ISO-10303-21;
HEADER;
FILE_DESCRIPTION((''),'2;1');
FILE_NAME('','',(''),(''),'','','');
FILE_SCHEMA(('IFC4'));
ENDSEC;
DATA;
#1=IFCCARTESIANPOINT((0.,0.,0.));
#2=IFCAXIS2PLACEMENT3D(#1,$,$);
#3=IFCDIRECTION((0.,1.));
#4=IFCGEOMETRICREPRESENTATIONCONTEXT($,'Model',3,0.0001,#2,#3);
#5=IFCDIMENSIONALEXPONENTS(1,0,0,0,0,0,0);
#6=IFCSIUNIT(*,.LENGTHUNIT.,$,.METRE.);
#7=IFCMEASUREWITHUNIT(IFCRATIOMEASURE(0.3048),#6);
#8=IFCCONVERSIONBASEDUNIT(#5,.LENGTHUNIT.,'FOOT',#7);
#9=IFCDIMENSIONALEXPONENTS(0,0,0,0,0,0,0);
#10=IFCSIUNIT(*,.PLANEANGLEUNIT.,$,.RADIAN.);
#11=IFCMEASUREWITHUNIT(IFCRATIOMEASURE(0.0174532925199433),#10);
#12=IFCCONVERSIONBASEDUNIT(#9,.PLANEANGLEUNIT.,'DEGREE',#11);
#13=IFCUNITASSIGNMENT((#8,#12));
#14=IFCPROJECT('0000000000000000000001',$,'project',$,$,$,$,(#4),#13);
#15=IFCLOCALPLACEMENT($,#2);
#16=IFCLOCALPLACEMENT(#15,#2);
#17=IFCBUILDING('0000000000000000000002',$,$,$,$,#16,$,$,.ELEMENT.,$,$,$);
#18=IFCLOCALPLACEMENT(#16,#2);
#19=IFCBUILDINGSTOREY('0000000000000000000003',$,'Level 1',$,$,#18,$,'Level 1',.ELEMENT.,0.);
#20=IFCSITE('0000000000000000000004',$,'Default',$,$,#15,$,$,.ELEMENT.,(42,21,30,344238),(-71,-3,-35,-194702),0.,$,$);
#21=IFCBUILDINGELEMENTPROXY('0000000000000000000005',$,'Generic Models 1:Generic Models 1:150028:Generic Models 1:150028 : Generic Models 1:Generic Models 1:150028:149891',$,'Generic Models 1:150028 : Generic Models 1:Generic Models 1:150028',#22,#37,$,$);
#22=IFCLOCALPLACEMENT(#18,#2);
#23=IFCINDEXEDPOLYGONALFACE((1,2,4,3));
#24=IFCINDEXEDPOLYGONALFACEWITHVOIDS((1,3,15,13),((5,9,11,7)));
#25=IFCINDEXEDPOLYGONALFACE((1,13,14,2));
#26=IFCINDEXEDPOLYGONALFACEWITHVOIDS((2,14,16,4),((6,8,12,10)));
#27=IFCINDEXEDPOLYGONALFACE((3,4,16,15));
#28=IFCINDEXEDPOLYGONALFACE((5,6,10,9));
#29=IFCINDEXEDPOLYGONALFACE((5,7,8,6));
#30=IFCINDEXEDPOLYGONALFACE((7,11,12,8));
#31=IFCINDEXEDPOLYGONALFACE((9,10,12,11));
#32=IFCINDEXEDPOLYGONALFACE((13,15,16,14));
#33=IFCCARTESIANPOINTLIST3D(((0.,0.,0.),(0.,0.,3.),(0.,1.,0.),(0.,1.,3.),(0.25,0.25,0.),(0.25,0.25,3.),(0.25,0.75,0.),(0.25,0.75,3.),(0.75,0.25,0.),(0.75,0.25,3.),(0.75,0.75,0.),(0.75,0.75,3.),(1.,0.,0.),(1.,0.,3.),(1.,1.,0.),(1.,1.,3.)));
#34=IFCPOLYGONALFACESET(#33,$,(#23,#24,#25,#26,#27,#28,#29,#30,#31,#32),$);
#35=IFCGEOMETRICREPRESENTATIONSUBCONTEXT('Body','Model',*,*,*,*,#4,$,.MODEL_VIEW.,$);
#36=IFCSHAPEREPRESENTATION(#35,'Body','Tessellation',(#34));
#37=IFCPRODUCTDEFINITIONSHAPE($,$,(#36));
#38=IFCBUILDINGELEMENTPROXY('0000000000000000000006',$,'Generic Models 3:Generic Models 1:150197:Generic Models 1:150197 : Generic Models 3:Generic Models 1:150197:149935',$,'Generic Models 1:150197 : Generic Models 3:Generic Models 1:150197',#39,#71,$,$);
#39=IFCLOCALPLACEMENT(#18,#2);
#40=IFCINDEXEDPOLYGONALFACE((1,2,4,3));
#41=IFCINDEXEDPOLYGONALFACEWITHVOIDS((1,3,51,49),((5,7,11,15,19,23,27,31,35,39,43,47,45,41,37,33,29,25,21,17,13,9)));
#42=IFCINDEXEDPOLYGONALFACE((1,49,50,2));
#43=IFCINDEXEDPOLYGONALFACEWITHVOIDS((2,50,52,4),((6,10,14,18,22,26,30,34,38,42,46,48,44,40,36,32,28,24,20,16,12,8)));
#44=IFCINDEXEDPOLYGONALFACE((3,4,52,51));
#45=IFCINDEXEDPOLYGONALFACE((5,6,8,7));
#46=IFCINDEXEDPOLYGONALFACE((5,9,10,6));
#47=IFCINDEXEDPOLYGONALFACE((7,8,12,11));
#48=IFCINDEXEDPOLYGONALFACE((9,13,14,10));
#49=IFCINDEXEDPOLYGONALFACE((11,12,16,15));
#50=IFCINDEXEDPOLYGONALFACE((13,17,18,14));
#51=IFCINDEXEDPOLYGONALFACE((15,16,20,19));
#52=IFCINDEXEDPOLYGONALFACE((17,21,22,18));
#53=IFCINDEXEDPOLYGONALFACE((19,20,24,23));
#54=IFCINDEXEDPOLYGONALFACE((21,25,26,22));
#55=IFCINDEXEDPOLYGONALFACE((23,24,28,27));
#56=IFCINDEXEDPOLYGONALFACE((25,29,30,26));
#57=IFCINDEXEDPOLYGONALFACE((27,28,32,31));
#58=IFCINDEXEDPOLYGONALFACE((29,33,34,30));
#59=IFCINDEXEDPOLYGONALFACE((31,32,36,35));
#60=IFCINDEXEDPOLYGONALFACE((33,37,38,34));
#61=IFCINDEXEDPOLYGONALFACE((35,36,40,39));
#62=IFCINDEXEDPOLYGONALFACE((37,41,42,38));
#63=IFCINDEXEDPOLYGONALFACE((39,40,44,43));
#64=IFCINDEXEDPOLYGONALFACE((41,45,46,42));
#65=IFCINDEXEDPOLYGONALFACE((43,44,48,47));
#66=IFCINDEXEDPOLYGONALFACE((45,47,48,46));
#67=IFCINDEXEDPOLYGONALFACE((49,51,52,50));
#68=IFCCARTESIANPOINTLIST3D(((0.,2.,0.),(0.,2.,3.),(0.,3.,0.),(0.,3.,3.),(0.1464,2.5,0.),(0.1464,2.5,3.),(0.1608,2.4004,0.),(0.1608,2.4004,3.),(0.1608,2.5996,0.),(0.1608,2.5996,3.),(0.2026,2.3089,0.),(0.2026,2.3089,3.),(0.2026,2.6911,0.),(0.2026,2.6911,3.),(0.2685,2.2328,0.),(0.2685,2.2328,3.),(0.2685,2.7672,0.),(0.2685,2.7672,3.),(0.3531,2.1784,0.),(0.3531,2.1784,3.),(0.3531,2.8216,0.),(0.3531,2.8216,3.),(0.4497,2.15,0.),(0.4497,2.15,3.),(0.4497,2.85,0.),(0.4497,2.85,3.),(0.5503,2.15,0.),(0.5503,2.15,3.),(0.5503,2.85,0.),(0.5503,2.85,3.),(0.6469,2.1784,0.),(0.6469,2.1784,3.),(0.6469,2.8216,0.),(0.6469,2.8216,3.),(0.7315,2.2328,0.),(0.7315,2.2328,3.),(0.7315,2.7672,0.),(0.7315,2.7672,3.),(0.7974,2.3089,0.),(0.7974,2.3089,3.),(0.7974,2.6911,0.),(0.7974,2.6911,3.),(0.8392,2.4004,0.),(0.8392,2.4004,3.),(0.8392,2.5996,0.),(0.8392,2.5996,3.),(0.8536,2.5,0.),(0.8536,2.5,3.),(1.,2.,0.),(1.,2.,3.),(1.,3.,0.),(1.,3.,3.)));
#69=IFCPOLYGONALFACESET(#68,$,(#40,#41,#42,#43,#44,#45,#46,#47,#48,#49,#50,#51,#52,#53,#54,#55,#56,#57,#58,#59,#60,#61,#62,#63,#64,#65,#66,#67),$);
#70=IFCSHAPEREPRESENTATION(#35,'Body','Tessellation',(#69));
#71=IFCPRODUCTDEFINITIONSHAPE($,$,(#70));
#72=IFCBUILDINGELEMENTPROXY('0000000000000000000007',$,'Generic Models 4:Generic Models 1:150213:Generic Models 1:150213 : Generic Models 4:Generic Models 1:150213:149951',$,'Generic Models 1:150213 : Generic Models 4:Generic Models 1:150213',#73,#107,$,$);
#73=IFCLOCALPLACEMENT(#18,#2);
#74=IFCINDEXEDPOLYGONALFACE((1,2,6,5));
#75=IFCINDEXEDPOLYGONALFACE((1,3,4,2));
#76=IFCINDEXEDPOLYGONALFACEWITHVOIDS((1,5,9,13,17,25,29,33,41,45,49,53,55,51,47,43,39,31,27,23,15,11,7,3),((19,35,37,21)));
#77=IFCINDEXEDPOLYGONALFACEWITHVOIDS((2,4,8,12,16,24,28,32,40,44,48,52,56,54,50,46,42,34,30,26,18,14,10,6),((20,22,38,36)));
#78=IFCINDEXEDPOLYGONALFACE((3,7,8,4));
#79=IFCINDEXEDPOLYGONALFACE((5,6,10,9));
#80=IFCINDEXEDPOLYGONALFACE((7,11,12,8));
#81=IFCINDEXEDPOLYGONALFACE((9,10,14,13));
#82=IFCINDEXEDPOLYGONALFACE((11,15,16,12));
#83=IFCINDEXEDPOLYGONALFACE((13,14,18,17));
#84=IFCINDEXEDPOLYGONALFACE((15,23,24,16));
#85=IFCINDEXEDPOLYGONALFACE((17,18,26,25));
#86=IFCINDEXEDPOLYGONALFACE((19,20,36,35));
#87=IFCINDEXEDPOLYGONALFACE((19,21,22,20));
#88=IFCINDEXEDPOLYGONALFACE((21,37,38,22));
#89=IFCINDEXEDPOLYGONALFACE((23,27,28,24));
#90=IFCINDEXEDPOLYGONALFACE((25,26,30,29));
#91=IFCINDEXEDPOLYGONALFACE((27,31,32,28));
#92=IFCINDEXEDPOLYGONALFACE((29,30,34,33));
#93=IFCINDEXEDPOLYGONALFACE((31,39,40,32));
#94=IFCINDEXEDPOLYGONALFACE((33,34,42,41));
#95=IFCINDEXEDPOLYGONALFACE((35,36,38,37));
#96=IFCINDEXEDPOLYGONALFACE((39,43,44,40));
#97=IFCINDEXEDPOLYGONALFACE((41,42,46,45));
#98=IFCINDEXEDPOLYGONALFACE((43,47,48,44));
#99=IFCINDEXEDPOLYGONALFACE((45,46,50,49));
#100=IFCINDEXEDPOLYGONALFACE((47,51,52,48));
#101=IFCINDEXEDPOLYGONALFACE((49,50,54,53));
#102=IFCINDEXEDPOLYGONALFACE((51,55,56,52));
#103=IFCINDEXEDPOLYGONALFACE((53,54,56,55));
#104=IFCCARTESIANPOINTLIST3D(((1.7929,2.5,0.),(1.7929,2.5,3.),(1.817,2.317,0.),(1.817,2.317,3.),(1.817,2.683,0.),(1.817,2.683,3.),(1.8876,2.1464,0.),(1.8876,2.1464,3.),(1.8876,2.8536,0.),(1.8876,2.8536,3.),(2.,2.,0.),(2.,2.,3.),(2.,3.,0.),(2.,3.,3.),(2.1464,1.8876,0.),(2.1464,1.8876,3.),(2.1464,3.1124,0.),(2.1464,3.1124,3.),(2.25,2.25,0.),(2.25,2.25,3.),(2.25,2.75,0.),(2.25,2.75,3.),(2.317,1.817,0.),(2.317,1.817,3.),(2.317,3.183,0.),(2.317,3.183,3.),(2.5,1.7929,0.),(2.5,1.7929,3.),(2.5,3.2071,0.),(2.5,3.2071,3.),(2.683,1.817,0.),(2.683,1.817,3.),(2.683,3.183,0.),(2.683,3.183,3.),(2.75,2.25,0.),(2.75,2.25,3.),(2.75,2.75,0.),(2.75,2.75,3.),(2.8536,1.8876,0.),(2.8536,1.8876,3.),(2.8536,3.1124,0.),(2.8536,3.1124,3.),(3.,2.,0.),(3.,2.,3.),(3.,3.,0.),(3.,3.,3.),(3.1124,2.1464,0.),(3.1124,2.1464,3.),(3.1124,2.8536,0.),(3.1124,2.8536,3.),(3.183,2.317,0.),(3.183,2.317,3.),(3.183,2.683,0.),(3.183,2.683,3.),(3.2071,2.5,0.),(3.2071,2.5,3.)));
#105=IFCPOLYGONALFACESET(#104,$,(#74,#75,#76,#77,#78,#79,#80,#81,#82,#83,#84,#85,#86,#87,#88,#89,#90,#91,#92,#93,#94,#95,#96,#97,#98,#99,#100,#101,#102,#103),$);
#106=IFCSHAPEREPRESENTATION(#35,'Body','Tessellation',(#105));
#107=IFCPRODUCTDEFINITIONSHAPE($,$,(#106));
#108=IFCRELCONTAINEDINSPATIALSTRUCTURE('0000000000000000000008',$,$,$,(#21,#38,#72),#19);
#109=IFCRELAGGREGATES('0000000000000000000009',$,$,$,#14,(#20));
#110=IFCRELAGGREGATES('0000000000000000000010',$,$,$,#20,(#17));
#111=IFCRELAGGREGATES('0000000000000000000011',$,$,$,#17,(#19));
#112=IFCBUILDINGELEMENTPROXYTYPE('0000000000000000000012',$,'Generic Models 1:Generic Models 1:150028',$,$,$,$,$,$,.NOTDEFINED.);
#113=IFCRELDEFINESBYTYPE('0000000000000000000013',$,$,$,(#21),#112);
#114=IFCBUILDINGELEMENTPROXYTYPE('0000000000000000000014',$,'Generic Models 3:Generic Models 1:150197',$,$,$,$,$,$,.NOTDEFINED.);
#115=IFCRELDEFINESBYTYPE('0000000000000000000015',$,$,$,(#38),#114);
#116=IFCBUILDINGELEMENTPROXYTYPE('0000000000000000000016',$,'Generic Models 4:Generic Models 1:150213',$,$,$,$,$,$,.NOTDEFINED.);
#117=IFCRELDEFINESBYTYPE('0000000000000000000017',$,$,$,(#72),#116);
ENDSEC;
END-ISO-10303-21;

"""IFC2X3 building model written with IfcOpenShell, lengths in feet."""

from ifc_helpers import new_model, entity, si_unit, converted_unit, direction, frame, frame_2d, origin, origin_2d_with_axis, place, context, subcontext, project, spatial, polyline, circle_curve, parameter, trimmed, segment, composite_curve, outline, extrude, source, transform, mapped, type_object, type_shapes, element, save


model = new_model("IFC2X3")

# Units and contexts
model_context = context("Model", 3, precision=0.0001, world=origin(), true_north=direction((0.0, 1.0)))
body_context = subcontext(model_context, "Body", "Model", "MODEL_VIEW")
ifc_project = project(units=[converted_unit("LENGTHUNIT", "FOOT", entity("IfcRatioMeasure", 0.3048), si_unit("LENGTHUNIT", "METRE"), dimensions=[1, 0, 0, 0, 0, 0, 0]), converted_unit("PLANEANGLEUNIT", "DEGREE", entity("IfcRatioMeasure", 0.0174532925199433), si_unit("PLANEANGLEUNIT", "RADIAN"), dimensions=[0, 0, 0, 0, 0, 0, 0])], contexts=[model_context])

# Site, building, storey
site_placement = place(None, origin())
site = spatial("IfcSite", under=ifc_project, at=site_placement, Name="Default", CompositionType="ELEMENT", RefLatitude=(42, 21, 30, 344238), RefLongitude=(-71, -3, -35, -194702), RefElevation=0.0)
building_placement = place(site_placement, origin())
building = spatial("IfcBuilding", under=site, at=building_placement, CompositionType="ELEMENT")
storey_placement = place(building_placement, origin())
storey = spatial("IfcBuildingStorey", under=building, at=storey_placement, Name="Level 1", LongName="Level 1", CompositionType="ELEMENT", Elevation=0.0)

# Building element proxies
building_element_proxy_type_1 = type_object("IfcBuildingElementProxyType", Name="Generic Models 1:Generic Models 1:150028", PredefinedType="NOTDEFINED")
shared_shape_1 = source(origin(), body_context, "Body", "SweptSolid", [
    extrude(outline(polyline([(-0.5, -0.5), (0.5, -0.5), (0.5, 0.5), (-0.5, 0.5), (-0.5, -0.5)]), holes=[polyline([(-0.25, 0.25), (0.25, 0.25), (0.25, -0.25), (-0.25, -0.25), (-0.25, 0.25)])]), frame((0.5, 0.5, 0.0), z_axis=(0.0, 0.0, 1.0), x_axis=(-1.0, 0.0, 0.0)), (0.0, 0.0, 1.0), 3.0),
])
type_shapes(building_element_proxy_type_1, [shared_shape_1])
proxy_1_placement = place(storey_placement, origin())
element("IfcBuildingElementProxy", 1, at=proxy_1_placement, inside=storey, type_object=building_element_proxy_type_1, Name="Generic Models 1:Generic Models 1:150028:Generic Models 1:150028 : Generic Models 1:Generic Models 1:150028:149891", ObjectType="Generic Models 1:150028 : Generic Models 1:Generic Models 1:150028", context=body_context, shape_type="MappedRepresentation", body=[
    mapped(shared_shape_1, transform((0.0, 0.0, 0.0), scale=1.0)),
])
building_element_proxy_type_2 = type_object("IfcBuildingElementProxyType", Name="Generic Models 3:Generic Models 1:150197", PredefinedType="NOTDEFINED")
shared_shape_2 = source(origin(), body_context, "Body", "SweptSolid", [
    extrude(outline(polyline([(-0.5, -0.5), (0.5, -0.5), (0.5, 0.5), (-0.5, 0.5), (-0.5, -0.5)]), holes=[composite_curve([segment(trimmed(circle_curve(frame_2d((0.0, 0.0), x_axis=(-1.0, 0.0)), 0.3536), [parameter(180.0)], [parameter(0.0)], True, "PARAMETER"), False, "CONTINUOUS"), segment(trimmed(circle_curve(frame_2d((0.0, 0.0), x_axis=(-1.0, 0.0)), 0.3536), [parameter(0.0)], [parameter(180.0)], True, "PARAMETER"), False, "CONTINUOUS")], self_intersect=False)]), frame((0.5, 2.5, 0.0), z_axis=(0.0, 0.0, 1.0), x_axis=(-1.0, 0.0, 0.0)), (0.0, 0.0, 1.0), 3.0),
])
type_shapes(building_element_proxy_type_2, [shared_shape_2])
proxy_2_placement = place(storey_placement, origin())
element("IfcBuildingElementProxy", 2, at=proxy_2_placement, inside=storey, type_object=building_element_proxy_type_2, Name="Generic Models 3:Generic Models 1:150197:Generic Models 1:150197 : Generic Models 3:Generic Models 1:150197:149935", ObjectType="Generic Models 1:150197 : Generic Models 3:Generic Models 1:150197", context=body_context, shape_type="MappedRepresentation", body=[
    mapped(shared_shape_2, transform((0.0, 0.0, 0.0), scale=1.0)),
])
building_element_proxy_type_3 = type_object("IfcBuildingElementProxyType", Name="Generic Models 4:Generic Models 1:150213", PredefinedType="NOTDEFINED")
shared_shape_3 = source(origin(), body_context, "Body", "SweptSolid", [
    extrude(outline(composite_curve([segment(trimmed(circle_curve(origin_2d_with_axis(), 0.7071), [parameter(0.0)], [parameter(180.0)], True, "PARAMETER"), True, "CONTINUOUS"), segment(trimmed(circle_curve(origin_2d_with_axis(), 0.7071), [parameter(180.0)], [parameter(360.0)], True, "PARAMETER"), True, "CONTINUOUS")], self_intersect=False), holes=[polyline([(0.25, -0.25), (-0.25, -0.25), (-0.25, 0.25), (0.25, 0.25), (0.25, -0.25)])]), frame((2.5, 2.5, 0.0)), (0.0, 0.0, 1.0), 3.0),
])
type_shapes(building_element_proxy_type_3, [shared_shape_3])
proxy_3_placement = place(storey_placement, origin())
element("IfcBuildingElementProxy", 3, at=proxy_3_placement, inside=storey, type_object=building_element_proxy_type_3, Name="Generic Models 4:Generic Models 1:150213:Generic Models 1:150213 : Generic Models 4:Generic Models 1:150213:149951", ObjectType="Generic Models 1:150213 : Generic Models 4:Generic Models 1:150213", context=body_context, shape_type="MappedRepresentation", body=[
    mapped(shared_shape_3, transform((0.0, 0.0, 0.0), scale=1.0)),
])

save(model, "model.ifc")
